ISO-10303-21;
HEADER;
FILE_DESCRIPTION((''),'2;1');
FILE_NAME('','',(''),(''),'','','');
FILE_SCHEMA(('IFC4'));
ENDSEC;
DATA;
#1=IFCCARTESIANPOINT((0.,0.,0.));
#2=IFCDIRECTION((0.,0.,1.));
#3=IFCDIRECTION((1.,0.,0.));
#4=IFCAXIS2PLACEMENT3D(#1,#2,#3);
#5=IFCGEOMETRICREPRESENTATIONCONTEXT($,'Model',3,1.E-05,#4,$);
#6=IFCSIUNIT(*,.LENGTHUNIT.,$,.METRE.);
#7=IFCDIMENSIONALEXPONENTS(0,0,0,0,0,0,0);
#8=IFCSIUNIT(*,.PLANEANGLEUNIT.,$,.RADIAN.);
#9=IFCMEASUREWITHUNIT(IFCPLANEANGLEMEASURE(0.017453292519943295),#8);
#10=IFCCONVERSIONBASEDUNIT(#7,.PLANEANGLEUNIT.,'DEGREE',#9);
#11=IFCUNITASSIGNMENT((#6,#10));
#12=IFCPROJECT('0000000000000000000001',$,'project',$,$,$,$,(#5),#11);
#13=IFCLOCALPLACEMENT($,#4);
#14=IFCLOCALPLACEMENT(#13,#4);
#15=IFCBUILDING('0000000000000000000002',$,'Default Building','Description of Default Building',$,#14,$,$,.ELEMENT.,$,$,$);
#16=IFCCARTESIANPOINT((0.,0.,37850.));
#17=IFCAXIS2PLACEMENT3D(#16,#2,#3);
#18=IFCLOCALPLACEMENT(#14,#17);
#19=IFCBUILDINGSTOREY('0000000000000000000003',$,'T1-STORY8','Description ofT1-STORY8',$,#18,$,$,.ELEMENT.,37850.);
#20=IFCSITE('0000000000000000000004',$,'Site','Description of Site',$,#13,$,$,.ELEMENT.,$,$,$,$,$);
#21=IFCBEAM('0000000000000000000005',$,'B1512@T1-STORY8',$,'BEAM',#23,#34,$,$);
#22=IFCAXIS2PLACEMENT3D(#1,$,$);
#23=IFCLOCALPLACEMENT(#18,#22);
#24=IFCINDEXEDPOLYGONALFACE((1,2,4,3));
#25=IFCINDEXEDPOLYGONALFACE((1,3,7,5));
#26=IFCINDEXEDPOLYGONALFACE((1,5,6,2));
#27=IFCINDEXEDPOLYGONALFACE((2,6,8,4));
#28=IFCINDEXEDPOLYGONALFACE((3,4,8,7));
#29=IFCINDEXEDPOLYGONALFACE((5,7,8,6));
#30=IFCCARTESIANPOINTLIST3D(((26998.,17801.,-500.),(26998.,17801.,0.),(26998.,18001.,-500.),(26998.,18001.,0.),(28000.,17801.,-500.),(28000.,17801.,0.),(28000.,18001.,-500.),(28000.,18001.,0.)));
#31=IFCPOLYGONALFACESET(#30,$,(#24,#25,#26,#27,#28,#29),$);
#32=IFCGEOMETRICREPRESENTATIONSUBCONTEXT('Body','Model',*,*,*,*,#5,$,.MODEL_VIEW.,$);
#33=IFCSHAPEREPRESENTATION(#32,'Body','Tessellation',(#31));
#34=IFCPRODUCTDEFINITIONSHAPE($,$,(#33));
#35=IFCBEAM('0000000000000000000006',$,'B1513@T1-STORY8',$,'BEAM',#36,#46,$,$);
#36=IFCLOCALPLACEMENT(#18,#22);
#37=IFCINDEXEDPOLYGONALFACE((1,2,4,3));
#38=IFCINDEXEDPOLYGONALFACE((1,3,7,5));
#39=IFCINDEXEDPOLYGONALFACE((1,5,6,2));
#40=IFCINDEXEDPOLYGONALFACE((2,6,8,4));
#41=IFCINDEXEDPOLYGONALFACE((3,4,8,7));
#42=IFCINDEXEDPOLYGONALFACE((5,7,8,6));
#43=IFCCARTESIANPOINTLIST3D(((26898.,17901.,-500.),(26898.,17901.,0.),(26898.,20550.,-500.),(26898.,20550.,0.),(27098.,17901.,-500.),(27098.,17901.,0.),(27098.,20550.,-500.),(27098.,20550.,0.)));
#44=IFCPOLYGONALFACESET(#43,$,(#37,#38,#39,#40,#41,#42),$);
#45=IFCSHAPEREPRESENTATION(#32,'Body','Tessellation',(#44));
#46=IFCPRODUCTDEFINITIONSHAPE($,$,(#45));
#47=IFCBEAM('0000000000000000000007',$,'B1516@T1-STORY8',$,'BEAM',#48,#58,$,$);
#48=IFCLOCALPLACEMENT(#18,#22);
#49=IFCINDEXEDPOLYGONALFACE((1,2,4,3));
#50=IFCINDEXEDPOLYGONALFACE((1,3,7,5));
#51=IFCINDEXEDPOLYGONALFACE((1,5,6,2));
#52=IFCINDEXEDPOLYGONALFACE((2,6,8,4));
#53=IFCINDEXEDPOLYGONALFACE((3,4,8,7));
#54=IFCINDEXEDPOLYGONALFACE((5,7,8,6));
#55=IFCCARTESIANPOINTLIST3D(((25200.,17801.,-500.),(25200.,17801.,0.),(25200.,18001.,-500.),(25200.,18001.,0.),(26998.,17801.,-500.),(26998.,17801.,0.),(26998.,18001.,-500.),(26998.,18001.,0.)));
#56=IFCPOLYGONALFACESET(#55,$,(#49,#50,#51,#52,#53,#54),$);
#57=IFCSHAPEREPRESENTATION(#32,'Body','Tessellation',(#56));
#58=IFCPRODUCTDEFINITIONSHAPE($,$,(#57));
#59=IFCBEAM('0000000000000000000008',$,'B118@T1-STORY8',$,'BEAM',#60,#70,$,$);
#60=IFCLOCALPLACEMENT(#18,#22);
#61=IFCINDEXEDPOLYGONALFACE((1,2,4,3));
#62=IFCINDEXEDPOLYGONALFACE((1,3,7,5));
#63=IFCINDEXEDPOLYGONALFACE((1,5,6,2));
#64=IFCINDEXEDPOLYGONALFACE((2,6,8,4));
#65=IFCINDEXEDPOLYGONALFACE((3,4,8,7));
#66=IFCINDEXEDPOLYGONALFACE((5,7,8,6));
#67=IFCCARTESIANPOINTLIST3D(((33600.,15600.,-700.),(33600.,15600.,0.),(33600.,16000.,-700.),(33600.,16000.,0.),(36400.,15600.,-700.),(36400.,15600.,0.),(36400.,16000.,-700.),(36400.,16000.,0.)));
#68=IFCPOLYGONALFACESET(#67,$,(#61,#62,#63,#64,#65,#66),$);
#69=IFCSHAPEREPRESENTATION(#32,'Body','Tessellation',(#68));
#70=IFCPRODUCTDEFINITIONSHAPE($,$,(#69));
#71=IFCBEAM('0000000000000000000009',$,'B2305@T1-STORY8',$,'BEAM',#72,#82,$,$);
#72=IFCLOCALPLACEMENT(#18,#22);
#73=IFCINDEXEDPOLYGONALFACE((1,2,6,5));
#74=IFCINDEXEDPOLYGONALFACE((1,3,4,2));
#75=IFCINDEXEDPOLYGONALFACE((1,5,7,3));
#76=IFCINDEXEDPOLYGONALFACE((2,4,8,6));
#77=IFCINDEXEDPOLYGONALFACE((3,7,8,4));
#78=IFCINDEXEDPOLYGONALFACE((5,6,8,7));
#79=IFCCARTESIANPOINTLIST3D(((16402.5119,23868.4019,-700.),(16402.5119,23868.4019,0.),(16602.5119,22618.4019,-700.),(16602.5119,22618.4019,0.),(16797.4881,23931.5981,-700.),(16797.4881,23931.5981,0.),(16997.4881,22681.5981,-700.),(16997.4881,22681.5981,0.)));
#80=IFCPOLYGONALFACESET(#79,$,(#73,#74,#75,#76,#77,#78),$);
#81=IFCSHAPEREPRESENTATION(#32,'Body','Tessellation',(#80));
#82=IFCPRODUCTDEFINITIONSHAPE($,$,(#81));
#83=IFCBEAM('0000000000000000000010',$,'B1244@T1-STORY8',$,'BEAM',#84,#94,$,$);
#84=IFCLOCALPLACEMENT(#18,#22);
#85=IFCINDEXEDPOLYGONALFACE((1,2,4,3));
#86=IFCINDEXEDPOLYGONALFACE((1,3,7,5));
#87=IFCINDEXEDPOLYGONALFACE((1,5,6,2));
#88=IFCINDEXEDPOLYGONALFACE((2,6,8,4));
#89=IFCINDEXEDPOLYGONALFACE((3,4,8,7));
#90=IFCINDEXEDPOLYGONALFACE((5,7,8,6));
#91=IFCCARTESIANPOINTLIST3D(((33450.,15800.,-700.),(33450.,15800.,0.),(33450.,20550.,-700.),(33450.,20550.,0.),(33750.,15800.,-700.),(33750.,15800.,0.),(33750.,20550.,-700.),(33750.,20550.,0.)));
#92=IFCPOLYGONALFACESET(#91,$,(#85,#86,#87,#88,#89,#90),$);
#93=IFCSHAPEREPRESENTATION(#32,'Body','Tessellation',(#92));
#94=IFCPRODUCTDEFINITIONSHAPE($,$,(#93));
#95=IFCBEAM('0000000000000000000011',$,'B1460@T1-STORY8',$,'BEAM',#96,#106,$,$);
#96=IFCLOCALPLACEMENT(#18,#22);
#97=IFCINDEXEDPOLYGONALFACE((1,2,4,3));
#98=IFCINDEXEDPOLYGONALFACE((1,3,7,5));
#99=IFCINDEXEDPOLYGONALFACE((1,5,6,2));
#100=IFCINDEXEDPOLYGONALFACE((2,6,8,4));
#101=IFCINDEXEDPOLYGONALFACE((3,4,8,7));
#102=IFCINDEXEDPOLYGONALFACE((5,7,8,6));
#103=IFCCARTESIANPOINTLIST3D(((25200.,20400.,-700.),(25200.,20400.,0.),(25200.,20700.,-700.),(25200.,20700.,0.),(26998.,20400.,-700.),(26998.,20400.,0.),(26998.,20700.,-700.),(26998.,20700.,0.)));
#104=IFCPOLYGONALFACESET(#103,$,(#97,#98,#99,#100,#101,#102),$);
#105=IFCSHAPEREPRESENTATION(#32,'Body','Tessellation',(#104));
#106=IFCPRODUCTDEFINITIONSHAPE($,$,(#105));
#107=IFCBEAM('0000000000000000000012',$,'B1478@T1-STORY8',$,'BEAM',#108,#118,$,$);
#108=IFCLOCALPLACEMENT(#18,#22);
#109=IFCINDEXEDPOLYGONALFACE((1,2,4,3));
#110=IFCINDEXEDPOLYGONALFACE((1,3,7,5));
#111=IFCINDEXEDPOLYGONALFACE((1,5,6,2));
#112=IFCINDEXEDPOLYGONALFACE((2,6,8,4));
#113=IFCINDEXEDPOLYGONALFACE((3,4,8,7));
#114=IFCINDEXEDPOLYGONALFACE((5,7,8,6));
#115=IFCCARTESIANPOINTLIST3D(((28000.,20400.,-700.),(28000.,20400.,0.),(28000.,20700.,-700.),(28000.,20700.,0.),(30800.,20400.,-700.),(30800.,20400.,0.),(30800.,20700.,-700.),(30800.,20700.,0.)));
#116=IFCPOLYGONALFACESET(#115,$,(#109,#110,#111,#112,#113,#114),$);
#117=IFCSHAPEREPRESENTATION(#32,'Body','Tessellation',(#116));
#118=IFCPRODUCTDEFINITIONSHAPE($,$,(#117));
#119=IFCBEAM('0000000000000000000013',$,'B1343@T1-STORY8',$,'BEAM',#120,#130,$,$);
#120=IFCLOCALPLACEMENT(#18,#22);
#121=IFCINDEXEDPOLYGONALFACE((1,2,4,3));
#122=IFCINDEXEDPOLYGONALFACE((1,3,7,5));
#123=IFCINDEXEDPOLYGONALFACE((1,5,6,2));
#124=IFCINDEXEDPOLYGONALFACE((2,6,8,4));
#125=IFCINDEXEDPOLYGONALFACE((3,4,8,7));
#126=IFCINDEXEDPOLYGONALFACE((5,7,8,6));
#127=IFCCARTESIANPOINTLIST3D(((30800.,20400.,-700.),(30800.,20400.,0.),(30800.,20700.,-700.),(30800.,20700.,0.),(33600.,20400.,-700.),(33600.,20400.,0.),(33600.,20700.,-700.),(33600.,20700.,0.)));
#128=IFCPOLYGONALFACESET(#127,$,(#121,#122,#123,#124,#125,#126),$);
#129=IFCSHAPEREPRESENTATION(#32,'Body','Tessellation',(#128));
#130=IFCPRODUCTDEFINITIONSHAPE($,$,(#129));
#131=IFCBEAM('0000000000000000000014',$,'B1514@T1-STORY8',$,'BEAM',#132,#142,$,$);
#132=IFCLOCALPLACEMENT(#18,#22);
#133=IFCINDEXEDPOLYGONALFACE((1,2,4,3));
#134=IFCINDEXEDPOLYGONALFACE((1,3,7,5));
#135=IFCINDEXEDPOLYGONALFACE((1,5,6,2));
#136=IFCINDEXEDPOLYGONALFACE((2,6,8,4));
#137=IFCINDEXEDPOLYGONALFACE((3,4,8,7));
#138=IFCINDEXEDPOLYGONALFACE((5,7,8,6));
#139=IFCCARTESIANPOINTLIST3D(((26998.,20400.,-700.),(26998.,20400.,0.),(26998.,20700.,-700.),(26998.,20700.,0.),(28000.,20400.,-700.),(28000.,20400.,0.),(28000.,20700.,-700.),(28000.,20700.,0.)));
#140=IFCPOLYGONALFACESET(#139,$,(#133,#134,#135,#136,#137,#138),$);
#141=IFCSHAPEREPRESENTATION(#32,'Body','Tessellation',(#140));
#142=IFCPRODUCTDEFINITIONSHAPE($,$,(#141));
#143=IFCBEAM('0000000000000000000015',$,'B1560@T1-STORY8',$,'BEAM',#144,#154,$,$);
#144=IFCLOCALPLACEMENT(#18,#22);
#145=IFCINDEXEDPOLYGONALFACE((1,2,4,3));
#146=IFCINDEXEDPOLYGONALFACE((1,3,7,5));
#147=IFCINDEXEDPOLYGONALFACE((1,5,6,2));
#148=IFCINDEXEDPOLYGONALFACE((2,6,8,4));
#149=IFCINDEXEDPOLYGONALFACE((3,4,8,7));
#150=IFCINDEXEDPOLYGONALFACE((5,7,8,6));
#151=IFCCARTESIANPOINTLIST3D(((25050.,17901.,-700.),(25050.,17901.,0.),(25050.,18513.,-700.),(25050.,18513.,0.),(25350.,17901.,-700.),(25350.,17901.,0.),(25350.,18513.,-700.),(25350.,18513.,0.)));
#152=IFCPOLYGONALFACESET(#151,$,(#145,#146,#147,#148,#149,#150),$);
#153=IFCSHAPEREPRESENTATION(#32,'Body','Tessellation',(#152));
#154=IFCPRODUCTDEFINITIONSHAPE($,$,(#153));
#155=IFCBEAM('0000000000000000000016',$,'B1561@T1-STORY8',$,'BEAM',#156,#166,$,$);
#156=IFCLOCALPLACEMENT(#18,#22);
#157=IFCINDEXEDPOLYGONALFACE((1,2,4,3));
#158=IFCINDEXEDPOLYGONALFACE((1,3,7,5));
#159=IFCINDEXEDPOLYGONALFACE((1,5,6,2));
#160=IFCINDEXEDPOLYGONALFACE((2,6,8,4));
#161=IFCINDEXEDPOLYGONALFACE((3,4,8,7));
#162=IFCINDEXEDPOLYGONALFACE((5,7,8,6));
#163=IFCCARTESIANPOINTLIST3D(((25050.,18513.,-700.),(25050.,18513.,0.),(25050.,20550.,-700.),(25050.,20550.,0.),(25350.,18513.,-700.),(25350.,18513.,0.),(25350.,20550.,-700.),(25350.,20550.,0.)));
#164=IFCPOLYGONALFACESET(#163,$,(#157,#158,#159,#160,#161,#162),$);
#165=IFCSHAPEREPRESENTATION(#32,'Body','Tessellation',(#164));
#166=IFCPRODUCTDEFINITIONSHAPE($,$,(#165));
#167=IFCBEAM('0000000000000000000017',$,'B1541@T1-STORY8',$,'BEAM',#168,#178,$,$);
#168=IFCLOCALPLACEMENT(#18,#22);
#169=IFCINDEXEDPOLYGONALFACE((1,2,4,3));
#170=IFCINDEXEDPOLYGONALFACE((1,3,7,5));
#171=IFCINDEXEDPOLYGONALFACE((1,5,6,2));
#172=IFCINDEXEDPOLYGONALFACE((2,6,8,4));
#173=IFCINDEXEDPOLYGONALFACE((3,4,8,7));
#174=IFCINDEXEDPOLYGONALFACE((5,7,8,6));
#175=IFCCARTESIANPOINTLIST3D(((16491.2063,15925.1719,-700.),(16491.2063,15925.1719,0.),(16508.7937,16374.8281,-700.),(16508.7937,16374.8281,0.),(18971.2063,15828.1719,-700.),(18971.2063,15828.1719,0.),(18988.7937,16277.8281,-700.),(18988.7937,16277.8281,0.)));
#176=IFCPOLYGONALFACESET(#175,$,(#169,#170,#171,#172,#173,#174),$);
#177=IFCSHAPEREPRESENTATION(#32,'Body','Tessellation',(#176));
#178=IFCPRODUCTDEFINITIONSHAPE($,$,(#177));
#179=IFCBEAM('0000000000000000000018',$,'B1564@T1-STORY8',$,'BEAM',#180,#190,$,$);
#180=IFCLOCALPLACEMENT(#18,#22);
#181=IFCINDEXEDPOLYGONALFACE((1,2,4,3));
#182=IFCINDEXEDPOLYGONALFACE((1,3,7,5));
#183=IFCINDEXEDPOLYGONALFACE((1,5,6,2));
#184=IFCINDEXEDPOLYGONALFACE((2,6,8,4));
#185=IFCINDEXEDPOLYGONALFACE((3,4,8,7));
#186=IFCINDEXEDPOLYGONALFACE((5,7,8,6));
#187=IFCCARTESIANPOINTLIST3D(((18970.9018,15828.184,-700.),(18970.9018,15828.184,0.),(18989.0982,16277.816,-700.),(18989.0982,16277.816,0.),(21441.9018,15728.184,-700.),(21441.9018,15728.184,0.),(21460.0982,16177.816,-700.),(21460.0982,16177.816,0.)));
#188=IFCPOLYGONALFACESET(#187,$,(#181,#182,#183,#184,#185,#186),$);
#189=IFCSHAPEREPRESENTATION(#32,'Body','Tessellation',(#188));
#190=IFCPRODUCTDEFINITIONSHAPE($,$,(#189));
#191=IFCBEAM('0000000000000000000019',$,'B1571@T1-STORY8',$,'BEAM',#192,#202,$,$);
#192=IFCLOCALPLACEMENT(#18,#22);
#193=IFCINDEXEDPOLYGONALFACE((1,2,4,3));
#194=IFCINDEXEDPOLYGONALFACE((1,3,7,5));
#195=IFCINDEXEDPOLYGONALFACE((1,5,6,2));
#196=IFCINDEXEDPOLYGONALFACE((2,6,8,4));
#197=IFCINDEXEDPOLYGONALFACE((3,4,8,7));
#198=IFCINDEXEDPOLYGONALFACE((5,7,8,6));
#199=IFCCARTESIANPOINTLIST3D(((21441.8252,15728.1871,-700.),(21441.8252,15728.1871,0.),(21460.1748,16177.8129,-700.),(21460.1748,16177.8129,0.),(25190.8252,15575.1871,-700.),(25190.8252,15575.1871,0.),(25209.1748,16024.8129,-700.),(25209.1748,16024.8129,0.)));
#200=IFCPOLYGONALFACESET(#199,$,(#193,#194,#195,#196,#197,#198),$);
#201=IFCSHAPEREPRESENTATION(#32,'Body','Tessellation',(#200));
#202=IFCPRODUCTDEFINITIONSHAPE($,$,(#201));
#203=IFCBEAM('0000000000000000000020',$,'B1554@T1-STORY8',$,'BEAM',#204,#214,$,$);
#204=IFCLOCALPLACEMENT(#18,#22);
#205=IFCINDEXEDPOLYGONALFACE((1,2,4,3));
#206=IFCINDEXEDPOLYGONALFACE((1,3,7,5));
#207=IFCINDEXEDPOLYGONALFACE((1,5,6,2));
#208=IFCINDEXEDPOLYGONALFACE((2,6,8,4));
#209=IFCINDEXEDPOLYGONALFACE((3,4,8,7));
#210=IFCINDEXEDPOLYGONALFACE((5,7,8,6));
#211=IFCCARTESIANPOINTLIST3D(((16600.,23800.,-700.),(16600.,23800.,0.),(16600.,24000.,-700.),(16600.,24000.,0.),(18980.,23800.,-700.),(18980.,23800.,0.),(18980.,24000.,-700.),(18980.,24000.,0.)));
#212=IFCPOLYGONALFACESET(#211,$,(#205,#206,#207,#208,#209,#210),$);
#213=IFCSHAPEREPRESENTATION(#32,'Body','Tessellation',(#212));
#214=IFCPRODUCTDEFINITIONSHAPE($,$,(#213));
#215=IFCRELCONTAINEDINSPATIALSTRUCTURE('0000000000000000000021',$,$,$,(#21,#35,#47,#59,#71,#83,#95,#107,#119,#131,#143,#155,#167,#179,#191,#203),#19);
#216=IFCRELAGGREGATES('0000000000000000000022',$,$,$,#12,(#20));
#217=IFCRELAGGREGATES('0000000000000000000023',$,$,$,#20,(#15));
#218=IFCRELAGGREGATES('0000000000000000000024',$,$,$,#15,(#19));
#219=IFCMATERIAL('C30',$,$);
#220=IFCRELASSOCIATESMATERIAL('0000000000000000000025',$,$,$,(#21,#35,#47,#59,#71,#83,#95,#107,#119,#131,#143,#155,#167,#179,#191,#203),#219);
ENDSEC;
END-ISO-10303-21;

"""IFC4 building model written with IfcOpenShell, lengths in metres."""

from ifc_helpers import new_model, entity, si_unit, converted_unit, frame, origin_with_axes, place, context, subcontext, project, spatial, rectangle, extrude, material, element, save


model = new_model("IFC4")

# Units and contexts
model_context = context("Model", 3, precision=1e-05, world=origin_with_axes())
body_context = subcontext(model_context, "Body", "Model", "MODEL_VIEW")
ifc_project = project(units=[si_unit("LENGTHUNIT", "METRE"), converted_unit("PLANEANGLEUNIT", "DEGREE", entity("IfcPlaneAngleMeasure", 0.017453292519943295), si_unit("PLANEANGLEUNIT", "RADIAN"), dimensions=[0, 0, 0, 0, 0, 0, 0])], contexts=[model_context])

# Site, building, storey
site_placement = place(None, origin_with_axes())
site = spatial("IfcSite", under=ifc_project, at=site_placement, Name="Site", Description="Description of Site", CompositionType="ELEMENT")
building_placement = place(site_placement, origin_with_axes())
building = spatial("IfcBuilding", under=site, at=building_placement, Name="Default Building", Description="Description of Default Building", CompositionType="ELEMENT")
storey_placement = place(building_placement, frame((0.0, 0.0, 37850.0), z_axis=(0.0, 0.0, 1.0), x_axis=(1.0, 0.0, 0.0)))
storey = spatial("IfcBuildingStorey", under=building, at=storey_placement, Name="T1-STORY8", Description="Description ofT1-STORY8", CompositionType="ELEMENT", Elevation=37850.0)

# Beams
ifc_material_1 = material(Name="C30")
beam_1_placement = place(storey_placement, frame((26998.0, 17901.0, -250.0), z_axis=(1.0, 0.0, 0.0), x_axis=(0.0, 1.0, 0.0)))
element("IfcBeam", 1, at=beam_1_placement, inside=storey, material=ifc_material_1, Name="B1512@T1-STORY8", ObjectType="BEAM", context=body_context, shape_type="SweptSolid", body=[
    extrude(rectangle(XDim=200.0, YDim=500.0), origin_with_axes(), (0.0, 0.0, 1.0), 1002.0),
])
beam_2_placement = place(storey_placement, frame((26998.0, 17901.0, -250.0), z_axis=(0.0, 1.0, 0.0), x_axis=(-1.0, 0.0, 0.0)))
element("IfcBeam", 2, at=beam_2_placement, inside=storey, material=ifc_material_1, Name="B1513@T1-STORY8", ObjectType="BEAM", context=body_context, shape_type="SweptSolid", body=[
    extrude(rectangle(XDim=200.0, YDim=500.0), origin_with_axes(), (0.0, 0.0, 1.0), 2649.0),
])
beam_3_placement = place(storey_placement, frame((25200.0, 17901.0, -250.0), z_axis=(1.0, 0.0, 0.0), x_axis=(0.0, 1.0, 0.0)))
element("IfcBeam", 3, at=beam_3_placement, inside=storey, material=ifc_material_1, Name="B1516@T1-STORY8", ObjectType="BEAM", context=body_context, shape_type="SweptSolid", body=[
    extrude(rectangle(XDim=200.0, YDim=500.0), origin_with_axes(), (0.0, 0.0, 1.0), 1798.0),
])
beam_4_placement = place(storey_placement, frame((33600.0, 15800.0, -350.0), z_axis=(1.0, 0.0, 0.0), x_axis=(0.0, 1.0, 0.0)))
element("IfcBeam", 4, at=beam_4_placement, inside=storey, material=ifc_material_1, Name="B118@T1-STORY8", ObjectType="BEAM", context=body_context, shape_type="SweptSolid", body=[
    extrude(rectangle(XDim=400.0, YDim=700.0), origin_with_axes(), (0.0, 0.0, 1.0), 2800.0),
])
beam_5_placement = place(storey_placement, frame((16600.0, 23900.0, -350.0), z_axis=(0.157991, -0.987441, 0.0), x_axis=(0.987441, 0.157991, 0.0)))
element("IfcBeam", 5, at=beam_5_placement, inside=storey, material=ifc_material_1, Name="B2305@T1-STORY8", ObjectType="BEAM", context=body_context, shape_type="SweptSolid", body=[
    extrude(rectangle(XDim=400.0, YDim=700.0), origin_with_axes(), (0.0, 0.0, 1.0), 1265.8989),
])
beam_6_placement = place(storey_placement, frame((33600.0, 15800.0, -350.0), z_axis=(0.0, 1.0, 0.0), x_axis=(-1.0, 0.0, 0.0)))
element("IfcBeam", 6, at=beam_6_placement, inside=storey, material=ifc_material_1, Name="B1244@T1-STORY8", ObjectType="BEAM", context=body_context, shape_type="SweptSolid", body=[
    extrude(rectangle(XDim=300.0, YDim=700.0), origin_with_axes(), (0.0, 0.0, 1.0), 4750.0),
])
beam_7_placement = place(storey_placement, frame((25200.0, 20550.0, -350.0), z_axis=(1.0, 0.0, 0.0), x_axis=(0.0, 1.0, 0.0)))
element("IfcBeam", 7, at=beam_7_placement, inside=storey, material=ifc_material_1, Name="B1460@T1-STORY8", ObjectType="BEAM", context=body_context, shape_type="SweptSolid", body=[
    extrude(rectangle(XDim=300.0, YDim=700.0), origin_with_axes(), (0.0, 0.0, 1.0), 1798.0),
])
for number, where, z_axis, x_axis, name in (
    (8, (28000.0, 20550.0, -350.0), (1.0, 0.0, 0.0), (0.0, 1.0, 0.0), "B1478@T1-STORY8"),
    (9, (30800.0, 20550.0, -350.0), (1.0, 0.0, 0.0), (0.0, 1.0, 0.0), "B1343@T1-STORY8"),
):
    element("IfcBeam", number, at=place(storey_placement, frame(where, z_axis=z_axis, x_axis=x_axis)), inside=storey, material=ifc_material_1, Name=name, ObjectType="BEAM", context=body_context, shape_type="SweptSolid", body=[
        extrude(rectangle(XDim=300.0, YDim=700.0), origin_with_axes(), (0.0, 0.0, 1.0), 2800.0),
    ])
beam_8_placement = place(storey_placement, frame((26998.0, 20550.0, -350.0), z_axis=(1.0, 0.0, 0.0), x_axis=(0.0, 1.0, 0.0)))
element("IfcBeam", 10, at=beam_8_placement, inside=storey, material=ifc_material_1, Name="B1514@T1-STORY8", ObjectType="BEAM", context=body_context, shape_type="SweptSolid", body=[
    extrude(rectangle(XDim=300.0, YDim=700.0), origin_with_axes(), (0.0, 0.0, 1.0), 1002.0),
])
beam_9_placement = place(storey_placement, frame((25200.0, 17901.0, -350.0), z_axis=(0.0, 1.0, 0.0), x_axis=(-1.0, 0.0, 0.0)))
element("IfcBeam", 11, at=beam_9_placement, inside=storey, material=ifc_material_1, Name="B1560@T1-STORY8", ObjectType="BEAM", context=body_context, shape_type="SweptSolid", body=[
    extrude(rectangle(XDim=300.0, YDim=700.0), origin_with_axes(), (0.0, 0.0, 1.0), 612.0),
])
beam_10_placement = place(storey_placement, frame((25200.0, 18513.0, -350.0), z_axis=(0.0, 1.0, 0.0), x_axis=(-1.0, 0.0, 0.0)))
element("IfcBeam", 12, at=beam_10_placement, inside=storey, material=ifc_material_1, Name="B1561@T1-STORY8", ObjectType="BEAM", context=body_context, shape_type="SweptSolid", body=[
    extrude(rectangle(XDim=300.0, YDim=700.0), origin_with_axes(), (0.0, 0.0, 1.0), 2037.0),
])
beam_11_placement = place(storey_placement, frame((16500.0, 16150.0, -350.0), z_axis=(0.999236, -0.039083, 0.0), x_axis=(0.039083, 0.999236, 0.0)))
element("IfcBeam", 13, at=beam_11_placement, inside=storey, material=ifc_material_1, Name="B1541@T1-STORY8", ObjectType="BEAM", context=body_context, shape_type="SweptSolid", body=[
    extrude(rectangle(XDim=450.0, YDim=700.0), origin_with_axes(), (0.0, 0.0, 1.0), 2481.8963),
])
beam_12_placement = place(storey_placement, frame((18980.0, 16053.0, -350.0), z_axis=(0.999182, -0.040436, 0.0), x_axis=(0.040436, 0.999182, 0.0)))
element("IfcBeam", 14, at=beam_12_placement, inside=storey, material=ifc_material_1, Name="B1564@T1-STORY8", ObjectType="BEAM", context=body_context, shape_type="SweptSolid", body=[
    extrude(rectangle(XDim=450.0, YDim=700.0), origin_with_axes(), (0.0, 0.0, 1.0), 2473.0226),
])
beam_13_placement = place(storey_placement, frame((21451.0, 15953.0, -350.0), z_axis=(0.999168, -0.040777, 0.0), x_axis=(0.040777, 0.999168, 0.0)))
element("IfcBeam", 15, at=beam_13_placement, inside=storey, material=ifc_material_1, Name="B1571@T1-STORY8", ObjectType="BEAM", context=body_context, shape_type="SweptSolid", body=[
    extrude(rectangle(XDim=450.0, YDim=700.0), origin_with_axes(), (0.0, 0.0, 1.0), 3752.1207),
])
beam_14_placement = place(storey_placement, frame((16600.0, 23900.0, -350.0), z_axis=(1.0, 0.0, 0.0), x_axis=(0.0, 1.0, 0.0)))
element("IfcBeam", 16, at=beam_14_placement, inside=storey, material=ifc_material_1, Name="B1554@T1-STORY8", ObjectType="BEAM", context=body_context, shape_type="SweptSolid", body=[
    extrude(rectangle(XDim=200.0, YDim=700.0), origin_with_axes(), (0.0, 0.0, 1.0), 2380.0),
])

save(model, "model.ifc")
